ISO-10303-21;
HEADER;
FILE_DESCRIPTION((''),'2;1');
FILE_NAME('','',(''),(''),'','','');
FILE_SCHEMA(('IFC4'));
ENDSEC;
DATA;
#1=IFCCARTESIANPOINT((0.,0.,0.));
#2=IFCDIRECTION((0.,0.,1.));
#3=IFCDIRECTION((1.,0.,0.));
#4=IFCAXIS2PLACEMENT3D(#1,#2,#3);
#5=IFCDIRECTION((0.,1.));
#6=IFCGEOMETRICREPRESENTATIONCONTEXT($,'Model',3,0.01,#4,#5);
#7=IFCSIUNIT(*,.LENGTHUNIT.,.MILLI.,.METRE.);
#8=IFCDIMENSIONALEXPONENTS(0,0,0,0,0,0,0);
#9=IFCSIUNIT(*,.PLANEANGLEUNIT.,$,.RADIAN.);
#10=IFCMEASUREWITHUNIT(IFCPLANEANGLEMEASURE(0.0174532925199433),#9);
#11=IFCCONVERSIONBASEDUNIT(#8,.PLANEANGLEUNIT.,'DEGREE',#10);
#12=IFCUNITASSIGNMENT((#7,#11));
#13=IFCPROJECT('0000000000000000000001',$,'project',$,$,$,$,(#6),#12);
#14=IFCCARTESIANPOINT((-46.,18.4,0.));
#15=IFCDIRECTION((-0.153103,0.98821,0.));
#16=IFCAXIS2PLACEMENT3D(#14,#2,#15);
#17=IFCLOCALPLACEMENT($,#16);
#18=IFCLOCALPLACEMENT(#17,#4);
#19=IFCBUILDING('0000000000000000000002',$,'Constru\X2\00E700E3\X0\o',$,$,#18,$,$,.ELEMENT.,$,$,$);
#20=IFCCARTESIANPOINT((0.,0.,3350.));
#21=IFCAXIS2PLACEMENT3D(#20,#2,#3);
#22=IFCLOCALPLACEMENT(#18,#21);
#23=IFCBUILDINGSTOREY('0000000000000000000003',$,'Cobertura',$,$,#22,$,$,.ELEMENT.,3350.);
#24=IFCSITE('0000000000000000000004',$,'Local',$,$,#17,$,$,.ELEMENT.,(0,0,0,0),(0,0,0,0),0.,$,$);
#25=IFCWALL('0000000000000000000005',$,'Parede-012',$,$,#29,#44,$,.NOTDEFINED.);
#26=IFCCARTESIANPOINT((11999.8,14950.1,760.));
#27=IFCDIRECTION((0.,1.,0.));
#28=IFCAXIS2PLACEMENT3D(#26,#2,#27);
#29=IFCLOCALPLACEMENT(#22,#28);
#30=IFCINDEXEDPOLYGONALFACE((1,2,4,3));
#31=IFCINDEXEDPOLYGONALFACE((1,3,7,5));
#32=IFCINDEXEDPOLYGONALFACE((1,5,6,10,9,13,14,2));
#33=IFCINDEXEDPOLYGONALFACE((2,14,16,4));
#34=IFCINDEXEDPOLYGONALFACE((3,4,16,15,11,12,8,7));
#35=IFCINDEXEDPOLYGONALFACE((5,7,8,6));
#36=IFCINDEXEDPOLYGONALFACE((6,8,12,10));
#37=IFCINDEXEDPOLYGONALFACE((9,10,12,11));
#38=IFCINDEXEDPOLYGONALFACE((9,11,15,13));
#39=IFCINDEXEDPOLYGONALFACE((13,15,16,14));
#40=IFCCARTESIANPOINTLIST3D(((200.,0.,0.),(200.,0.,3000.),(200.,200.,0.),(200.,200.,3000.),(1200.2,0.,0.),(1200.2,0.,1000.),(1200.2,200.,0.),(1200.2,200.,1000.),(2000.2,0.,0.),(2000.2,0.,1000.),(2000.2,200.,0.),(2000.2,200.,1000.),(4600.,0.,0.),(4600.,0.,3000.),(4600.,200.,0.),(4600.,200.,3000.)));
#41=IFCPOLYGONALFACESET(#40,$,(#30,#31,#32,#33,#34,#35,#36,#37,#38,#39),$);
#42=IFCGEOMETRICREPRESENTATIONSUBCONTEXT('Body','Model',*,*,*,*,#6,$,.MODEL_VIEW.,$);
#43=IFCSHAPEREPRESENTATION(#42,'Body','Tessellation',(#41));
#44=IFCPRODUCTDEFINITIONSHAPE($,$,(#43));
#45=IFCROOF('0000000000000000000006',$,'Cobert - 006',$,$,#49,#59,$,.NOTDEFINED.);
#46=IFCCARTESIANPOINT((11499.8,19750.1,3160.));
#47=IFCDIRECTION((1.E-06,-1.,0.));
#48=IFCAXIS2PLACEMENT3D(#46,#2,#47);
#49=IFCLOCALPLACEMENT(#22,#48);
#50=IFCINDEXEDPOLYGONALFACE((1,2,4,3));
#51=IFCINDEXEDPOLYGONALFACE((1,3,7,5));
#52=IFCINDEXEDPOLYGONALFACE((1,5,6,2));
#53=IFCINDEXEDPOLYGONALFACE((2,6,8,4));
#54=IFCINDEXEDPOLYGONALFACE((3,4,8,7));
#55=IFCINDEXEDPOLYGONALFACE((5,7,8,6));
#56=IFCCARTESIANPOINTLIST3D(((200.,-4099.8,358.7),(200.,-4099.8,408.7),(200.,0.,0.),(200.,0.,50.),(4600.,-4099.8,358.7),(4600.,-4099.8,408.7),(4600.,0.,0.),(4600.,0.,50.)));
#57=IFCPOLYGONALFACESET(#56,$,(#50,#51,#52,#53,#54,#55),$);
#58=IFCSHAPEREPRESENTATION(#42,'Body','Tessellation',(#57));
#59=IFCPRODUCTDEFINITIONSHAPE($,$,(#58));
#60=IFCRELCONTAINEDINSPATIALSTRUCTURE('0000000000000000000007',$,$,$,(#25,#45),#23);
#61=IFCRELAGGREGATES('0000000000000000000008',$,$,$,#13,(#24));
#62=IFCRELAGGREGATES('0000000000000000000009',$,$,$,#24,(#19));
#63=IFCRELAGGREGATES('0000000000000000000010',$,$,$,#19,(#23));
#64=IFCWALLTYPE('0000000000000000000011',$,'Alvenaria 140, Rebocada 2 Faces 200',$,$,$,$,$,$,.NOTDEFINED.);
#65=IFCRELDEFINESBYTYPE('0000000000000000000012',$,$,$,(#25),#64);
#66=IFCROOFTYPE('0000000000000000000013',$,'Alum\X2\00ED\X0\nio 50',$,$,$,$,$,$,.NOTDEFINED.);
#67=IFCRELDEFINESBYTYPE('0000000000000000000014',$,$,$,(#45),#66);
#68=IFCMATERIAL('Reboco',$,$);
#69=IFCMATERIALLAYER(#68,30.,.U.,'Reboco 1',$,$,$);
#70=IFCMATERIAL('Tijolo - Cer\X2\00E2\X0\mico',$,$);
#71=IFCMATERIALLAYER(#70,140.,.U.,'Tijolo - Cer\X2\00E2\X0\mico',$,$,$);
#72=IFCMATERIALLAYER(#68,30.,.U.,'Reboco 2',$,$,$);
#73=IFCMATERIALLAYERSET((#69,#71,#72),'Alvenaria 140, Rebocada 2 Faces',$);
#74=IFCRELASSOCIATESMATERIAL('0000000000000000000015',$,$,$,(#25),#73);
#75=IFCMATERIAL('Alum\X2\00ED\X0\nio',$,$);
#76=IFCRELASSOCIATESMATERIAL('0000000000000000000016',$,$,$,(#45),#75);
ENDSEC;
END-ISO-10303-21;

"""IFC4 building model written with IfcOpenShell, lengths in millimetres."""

from ifc_helpers import new_model, entity, si_unit, converted_unit, direction, frame, origin_with_axes, origin_2d_with_axis, place, context, subcontext, project, spatial, line, indexed_curve, rectangle, outline, extrude, material, layer, layer_set, layer_usage, type_object, element, save


model = new_model("IFC4")

# Units and contexts
model_context = context("Model", 3, precision=0.01, world=origin_with_axes(), true_north=direction((0.0, 1.0)))
body_context = subcontext(model_context, "Body", "Model", "MODEL_VIEW")
ifc_project = project(units=[si_unit("LENGTHUNIT", "METRE", prefix="MILLI"), converted_unit("PLANEANGLEUNIT", "DEGREE", entity("IfcPlaneAngleMeasure", 0.0174532925199433), si_unit("PLANEANGLEUNIT", "RADIAN"), dimensions=[0, 0, 0, 0, 0, 0, 0])], contexts=[model_context])

# Site, building, storey
site_placement = place(None, frame((-46.0, 18.4, 0.0), z_axis=(0.0, 0.0, 1.0), x_axis=(-0.153103, 0.98821, 0.0)))
site = spatial("IfcSite", under=ifc_project, at=site_placement, Name="Local", CompositionType="ELEMENT", RefLatitude=(0, 0, 0, 0), RefLongitude=(0, 0, 0, 0), RefElevation=0.0)
building_placement = place(site_placement, origin_with_axes())
building = spatial("IfcBuilding", under=site, at=building_placement, Name="Construção", CompositionType="ELEMENT")
storey_placement = place(building_placement, frame((0.0, 0.0, 3350.0), z_axis=(0.0, 0.0, 1.0), x_axis=(1.0, 0.0, 0.0)))
storey = spatial("IfcBuildingStorey", under=building, at=storey_placement, Name="Cobertura", CompositionType="ELEMENT", Elevation=3350.0)

# Shared definitions
ifc_material_1 = material(Name="Reboco")
ifc_layer_1 = layer(ifc_material_1, 30.0, ventilated="UNKNOWN", Name="Reboco 1")
ifc_material_2 = material(Name="Tijolo - Cerâmico")
ifc_layer_2 = layer(ifc_material_2, 140.0, ventilated="UNKNOWN", Name="Tijolo - Cerâmico")
ifc_layer_3 = layer(ifc_material_1, 30.0, ventilated="UNKNOWN", Name="Reboco 2")
ifc_layer_set_1 = layer_set([ifc_layer_1, ifc_layer_2, ifc_layer_3], Name="Alvenaria 140, Rebocada 2 Faces")
wall_type = type_object("IfcWallType", Name="Alvenaria 140, Rebocada 2 Faces 200", PredefinedType="NOTDEFINED")

# Wall, opening
ifc_layer_usage_1 = layer_usage(ifc_layer_set_1, "AXIS2", "POSITIVE", 0.0)
wall_1_placement = place(storey_placement, frame((11999.8, 14950.1, 760.0), z_axis=(0.0, 0.0, 1.0), x_axis=(0.0, 1.0, 0.0)))
wall_1 = element("IfcWall", 1, at=wall_1_placement, inside=storey, type_object=wall_type, material=ifc_layer_usage_1, Name="Parede-012", PredefinedType="NOTDEFINED", context=body_context, shape_type="SweptSolid", body=[
    extrude(outline(indexed_curve([(200.0, 0.0), (4600.0, 0.0), (4600.0, 200.0), (200.0, 200.0)], segments=[line(1, 2, 3, 4, 1)])), origin_with_axes(), (0.0, 0.0, 1.0), 3000.0),
])
opening_1_placement = place(wall_1_placement, frame((1600.2, 0.0, 0.0), z_axis=(0.0, 0.0, 1.0), x_axis=(1.0, 0.0, 0.0)))
element("IfcOpeningElement", 2, at=opening_1_placement, cuts=wall_1, context=body_context, shape_type="SweptSolid", body=[
    extrude(rectangle(XDim=800.0, YDim=1000.0, at=origin_2d_with_axis()), frame((0.0, 200.0, 500.0), z_axis=(0.0, -1.0, 0.0), x_axis=(-1.0, 0.0, 0.0)), (0.0, 0.0, 1.0), 600.0),
])

# Roof
ifc_material_3 = material(Name="Alumínio")
roof_type = type_object("IfcRoofType", Name="Alumínio 50", PredefinedType="NOTDEFINED")
roof_1_placement = place(storey_placement, frame((11499.8, 19750.1, 3160.0), z_axis=(0.0, 0.0, 1.0), x_axis=(0.000001, -1.0, 0.0)))
element("IfcRoof", 3, at=roof_1_placement, inside=storey, type_object=roof_type, material=ifc_material_3, Name="Cobert - 006", PredefinedType="NOTDEFINED", context=body_context, shape_type="SweptSolid", body=[
    extrude(outline(indexed_curve([(200.0, -4115.5), (4600.0, -4115.5), (4600.0, 0.0), (200.0, 0.0)], segments=[line(1, 2, 3, 4, 1)])), frame((0.0, 0.0, 0.0), z_axis=(0.0, 0.087156, 0.996195), x_axis=(1.0, 0.0, 0.0)), (0.0, -0.087156, 0.996195), 50.0),
])

save(model, "model.ifc")
